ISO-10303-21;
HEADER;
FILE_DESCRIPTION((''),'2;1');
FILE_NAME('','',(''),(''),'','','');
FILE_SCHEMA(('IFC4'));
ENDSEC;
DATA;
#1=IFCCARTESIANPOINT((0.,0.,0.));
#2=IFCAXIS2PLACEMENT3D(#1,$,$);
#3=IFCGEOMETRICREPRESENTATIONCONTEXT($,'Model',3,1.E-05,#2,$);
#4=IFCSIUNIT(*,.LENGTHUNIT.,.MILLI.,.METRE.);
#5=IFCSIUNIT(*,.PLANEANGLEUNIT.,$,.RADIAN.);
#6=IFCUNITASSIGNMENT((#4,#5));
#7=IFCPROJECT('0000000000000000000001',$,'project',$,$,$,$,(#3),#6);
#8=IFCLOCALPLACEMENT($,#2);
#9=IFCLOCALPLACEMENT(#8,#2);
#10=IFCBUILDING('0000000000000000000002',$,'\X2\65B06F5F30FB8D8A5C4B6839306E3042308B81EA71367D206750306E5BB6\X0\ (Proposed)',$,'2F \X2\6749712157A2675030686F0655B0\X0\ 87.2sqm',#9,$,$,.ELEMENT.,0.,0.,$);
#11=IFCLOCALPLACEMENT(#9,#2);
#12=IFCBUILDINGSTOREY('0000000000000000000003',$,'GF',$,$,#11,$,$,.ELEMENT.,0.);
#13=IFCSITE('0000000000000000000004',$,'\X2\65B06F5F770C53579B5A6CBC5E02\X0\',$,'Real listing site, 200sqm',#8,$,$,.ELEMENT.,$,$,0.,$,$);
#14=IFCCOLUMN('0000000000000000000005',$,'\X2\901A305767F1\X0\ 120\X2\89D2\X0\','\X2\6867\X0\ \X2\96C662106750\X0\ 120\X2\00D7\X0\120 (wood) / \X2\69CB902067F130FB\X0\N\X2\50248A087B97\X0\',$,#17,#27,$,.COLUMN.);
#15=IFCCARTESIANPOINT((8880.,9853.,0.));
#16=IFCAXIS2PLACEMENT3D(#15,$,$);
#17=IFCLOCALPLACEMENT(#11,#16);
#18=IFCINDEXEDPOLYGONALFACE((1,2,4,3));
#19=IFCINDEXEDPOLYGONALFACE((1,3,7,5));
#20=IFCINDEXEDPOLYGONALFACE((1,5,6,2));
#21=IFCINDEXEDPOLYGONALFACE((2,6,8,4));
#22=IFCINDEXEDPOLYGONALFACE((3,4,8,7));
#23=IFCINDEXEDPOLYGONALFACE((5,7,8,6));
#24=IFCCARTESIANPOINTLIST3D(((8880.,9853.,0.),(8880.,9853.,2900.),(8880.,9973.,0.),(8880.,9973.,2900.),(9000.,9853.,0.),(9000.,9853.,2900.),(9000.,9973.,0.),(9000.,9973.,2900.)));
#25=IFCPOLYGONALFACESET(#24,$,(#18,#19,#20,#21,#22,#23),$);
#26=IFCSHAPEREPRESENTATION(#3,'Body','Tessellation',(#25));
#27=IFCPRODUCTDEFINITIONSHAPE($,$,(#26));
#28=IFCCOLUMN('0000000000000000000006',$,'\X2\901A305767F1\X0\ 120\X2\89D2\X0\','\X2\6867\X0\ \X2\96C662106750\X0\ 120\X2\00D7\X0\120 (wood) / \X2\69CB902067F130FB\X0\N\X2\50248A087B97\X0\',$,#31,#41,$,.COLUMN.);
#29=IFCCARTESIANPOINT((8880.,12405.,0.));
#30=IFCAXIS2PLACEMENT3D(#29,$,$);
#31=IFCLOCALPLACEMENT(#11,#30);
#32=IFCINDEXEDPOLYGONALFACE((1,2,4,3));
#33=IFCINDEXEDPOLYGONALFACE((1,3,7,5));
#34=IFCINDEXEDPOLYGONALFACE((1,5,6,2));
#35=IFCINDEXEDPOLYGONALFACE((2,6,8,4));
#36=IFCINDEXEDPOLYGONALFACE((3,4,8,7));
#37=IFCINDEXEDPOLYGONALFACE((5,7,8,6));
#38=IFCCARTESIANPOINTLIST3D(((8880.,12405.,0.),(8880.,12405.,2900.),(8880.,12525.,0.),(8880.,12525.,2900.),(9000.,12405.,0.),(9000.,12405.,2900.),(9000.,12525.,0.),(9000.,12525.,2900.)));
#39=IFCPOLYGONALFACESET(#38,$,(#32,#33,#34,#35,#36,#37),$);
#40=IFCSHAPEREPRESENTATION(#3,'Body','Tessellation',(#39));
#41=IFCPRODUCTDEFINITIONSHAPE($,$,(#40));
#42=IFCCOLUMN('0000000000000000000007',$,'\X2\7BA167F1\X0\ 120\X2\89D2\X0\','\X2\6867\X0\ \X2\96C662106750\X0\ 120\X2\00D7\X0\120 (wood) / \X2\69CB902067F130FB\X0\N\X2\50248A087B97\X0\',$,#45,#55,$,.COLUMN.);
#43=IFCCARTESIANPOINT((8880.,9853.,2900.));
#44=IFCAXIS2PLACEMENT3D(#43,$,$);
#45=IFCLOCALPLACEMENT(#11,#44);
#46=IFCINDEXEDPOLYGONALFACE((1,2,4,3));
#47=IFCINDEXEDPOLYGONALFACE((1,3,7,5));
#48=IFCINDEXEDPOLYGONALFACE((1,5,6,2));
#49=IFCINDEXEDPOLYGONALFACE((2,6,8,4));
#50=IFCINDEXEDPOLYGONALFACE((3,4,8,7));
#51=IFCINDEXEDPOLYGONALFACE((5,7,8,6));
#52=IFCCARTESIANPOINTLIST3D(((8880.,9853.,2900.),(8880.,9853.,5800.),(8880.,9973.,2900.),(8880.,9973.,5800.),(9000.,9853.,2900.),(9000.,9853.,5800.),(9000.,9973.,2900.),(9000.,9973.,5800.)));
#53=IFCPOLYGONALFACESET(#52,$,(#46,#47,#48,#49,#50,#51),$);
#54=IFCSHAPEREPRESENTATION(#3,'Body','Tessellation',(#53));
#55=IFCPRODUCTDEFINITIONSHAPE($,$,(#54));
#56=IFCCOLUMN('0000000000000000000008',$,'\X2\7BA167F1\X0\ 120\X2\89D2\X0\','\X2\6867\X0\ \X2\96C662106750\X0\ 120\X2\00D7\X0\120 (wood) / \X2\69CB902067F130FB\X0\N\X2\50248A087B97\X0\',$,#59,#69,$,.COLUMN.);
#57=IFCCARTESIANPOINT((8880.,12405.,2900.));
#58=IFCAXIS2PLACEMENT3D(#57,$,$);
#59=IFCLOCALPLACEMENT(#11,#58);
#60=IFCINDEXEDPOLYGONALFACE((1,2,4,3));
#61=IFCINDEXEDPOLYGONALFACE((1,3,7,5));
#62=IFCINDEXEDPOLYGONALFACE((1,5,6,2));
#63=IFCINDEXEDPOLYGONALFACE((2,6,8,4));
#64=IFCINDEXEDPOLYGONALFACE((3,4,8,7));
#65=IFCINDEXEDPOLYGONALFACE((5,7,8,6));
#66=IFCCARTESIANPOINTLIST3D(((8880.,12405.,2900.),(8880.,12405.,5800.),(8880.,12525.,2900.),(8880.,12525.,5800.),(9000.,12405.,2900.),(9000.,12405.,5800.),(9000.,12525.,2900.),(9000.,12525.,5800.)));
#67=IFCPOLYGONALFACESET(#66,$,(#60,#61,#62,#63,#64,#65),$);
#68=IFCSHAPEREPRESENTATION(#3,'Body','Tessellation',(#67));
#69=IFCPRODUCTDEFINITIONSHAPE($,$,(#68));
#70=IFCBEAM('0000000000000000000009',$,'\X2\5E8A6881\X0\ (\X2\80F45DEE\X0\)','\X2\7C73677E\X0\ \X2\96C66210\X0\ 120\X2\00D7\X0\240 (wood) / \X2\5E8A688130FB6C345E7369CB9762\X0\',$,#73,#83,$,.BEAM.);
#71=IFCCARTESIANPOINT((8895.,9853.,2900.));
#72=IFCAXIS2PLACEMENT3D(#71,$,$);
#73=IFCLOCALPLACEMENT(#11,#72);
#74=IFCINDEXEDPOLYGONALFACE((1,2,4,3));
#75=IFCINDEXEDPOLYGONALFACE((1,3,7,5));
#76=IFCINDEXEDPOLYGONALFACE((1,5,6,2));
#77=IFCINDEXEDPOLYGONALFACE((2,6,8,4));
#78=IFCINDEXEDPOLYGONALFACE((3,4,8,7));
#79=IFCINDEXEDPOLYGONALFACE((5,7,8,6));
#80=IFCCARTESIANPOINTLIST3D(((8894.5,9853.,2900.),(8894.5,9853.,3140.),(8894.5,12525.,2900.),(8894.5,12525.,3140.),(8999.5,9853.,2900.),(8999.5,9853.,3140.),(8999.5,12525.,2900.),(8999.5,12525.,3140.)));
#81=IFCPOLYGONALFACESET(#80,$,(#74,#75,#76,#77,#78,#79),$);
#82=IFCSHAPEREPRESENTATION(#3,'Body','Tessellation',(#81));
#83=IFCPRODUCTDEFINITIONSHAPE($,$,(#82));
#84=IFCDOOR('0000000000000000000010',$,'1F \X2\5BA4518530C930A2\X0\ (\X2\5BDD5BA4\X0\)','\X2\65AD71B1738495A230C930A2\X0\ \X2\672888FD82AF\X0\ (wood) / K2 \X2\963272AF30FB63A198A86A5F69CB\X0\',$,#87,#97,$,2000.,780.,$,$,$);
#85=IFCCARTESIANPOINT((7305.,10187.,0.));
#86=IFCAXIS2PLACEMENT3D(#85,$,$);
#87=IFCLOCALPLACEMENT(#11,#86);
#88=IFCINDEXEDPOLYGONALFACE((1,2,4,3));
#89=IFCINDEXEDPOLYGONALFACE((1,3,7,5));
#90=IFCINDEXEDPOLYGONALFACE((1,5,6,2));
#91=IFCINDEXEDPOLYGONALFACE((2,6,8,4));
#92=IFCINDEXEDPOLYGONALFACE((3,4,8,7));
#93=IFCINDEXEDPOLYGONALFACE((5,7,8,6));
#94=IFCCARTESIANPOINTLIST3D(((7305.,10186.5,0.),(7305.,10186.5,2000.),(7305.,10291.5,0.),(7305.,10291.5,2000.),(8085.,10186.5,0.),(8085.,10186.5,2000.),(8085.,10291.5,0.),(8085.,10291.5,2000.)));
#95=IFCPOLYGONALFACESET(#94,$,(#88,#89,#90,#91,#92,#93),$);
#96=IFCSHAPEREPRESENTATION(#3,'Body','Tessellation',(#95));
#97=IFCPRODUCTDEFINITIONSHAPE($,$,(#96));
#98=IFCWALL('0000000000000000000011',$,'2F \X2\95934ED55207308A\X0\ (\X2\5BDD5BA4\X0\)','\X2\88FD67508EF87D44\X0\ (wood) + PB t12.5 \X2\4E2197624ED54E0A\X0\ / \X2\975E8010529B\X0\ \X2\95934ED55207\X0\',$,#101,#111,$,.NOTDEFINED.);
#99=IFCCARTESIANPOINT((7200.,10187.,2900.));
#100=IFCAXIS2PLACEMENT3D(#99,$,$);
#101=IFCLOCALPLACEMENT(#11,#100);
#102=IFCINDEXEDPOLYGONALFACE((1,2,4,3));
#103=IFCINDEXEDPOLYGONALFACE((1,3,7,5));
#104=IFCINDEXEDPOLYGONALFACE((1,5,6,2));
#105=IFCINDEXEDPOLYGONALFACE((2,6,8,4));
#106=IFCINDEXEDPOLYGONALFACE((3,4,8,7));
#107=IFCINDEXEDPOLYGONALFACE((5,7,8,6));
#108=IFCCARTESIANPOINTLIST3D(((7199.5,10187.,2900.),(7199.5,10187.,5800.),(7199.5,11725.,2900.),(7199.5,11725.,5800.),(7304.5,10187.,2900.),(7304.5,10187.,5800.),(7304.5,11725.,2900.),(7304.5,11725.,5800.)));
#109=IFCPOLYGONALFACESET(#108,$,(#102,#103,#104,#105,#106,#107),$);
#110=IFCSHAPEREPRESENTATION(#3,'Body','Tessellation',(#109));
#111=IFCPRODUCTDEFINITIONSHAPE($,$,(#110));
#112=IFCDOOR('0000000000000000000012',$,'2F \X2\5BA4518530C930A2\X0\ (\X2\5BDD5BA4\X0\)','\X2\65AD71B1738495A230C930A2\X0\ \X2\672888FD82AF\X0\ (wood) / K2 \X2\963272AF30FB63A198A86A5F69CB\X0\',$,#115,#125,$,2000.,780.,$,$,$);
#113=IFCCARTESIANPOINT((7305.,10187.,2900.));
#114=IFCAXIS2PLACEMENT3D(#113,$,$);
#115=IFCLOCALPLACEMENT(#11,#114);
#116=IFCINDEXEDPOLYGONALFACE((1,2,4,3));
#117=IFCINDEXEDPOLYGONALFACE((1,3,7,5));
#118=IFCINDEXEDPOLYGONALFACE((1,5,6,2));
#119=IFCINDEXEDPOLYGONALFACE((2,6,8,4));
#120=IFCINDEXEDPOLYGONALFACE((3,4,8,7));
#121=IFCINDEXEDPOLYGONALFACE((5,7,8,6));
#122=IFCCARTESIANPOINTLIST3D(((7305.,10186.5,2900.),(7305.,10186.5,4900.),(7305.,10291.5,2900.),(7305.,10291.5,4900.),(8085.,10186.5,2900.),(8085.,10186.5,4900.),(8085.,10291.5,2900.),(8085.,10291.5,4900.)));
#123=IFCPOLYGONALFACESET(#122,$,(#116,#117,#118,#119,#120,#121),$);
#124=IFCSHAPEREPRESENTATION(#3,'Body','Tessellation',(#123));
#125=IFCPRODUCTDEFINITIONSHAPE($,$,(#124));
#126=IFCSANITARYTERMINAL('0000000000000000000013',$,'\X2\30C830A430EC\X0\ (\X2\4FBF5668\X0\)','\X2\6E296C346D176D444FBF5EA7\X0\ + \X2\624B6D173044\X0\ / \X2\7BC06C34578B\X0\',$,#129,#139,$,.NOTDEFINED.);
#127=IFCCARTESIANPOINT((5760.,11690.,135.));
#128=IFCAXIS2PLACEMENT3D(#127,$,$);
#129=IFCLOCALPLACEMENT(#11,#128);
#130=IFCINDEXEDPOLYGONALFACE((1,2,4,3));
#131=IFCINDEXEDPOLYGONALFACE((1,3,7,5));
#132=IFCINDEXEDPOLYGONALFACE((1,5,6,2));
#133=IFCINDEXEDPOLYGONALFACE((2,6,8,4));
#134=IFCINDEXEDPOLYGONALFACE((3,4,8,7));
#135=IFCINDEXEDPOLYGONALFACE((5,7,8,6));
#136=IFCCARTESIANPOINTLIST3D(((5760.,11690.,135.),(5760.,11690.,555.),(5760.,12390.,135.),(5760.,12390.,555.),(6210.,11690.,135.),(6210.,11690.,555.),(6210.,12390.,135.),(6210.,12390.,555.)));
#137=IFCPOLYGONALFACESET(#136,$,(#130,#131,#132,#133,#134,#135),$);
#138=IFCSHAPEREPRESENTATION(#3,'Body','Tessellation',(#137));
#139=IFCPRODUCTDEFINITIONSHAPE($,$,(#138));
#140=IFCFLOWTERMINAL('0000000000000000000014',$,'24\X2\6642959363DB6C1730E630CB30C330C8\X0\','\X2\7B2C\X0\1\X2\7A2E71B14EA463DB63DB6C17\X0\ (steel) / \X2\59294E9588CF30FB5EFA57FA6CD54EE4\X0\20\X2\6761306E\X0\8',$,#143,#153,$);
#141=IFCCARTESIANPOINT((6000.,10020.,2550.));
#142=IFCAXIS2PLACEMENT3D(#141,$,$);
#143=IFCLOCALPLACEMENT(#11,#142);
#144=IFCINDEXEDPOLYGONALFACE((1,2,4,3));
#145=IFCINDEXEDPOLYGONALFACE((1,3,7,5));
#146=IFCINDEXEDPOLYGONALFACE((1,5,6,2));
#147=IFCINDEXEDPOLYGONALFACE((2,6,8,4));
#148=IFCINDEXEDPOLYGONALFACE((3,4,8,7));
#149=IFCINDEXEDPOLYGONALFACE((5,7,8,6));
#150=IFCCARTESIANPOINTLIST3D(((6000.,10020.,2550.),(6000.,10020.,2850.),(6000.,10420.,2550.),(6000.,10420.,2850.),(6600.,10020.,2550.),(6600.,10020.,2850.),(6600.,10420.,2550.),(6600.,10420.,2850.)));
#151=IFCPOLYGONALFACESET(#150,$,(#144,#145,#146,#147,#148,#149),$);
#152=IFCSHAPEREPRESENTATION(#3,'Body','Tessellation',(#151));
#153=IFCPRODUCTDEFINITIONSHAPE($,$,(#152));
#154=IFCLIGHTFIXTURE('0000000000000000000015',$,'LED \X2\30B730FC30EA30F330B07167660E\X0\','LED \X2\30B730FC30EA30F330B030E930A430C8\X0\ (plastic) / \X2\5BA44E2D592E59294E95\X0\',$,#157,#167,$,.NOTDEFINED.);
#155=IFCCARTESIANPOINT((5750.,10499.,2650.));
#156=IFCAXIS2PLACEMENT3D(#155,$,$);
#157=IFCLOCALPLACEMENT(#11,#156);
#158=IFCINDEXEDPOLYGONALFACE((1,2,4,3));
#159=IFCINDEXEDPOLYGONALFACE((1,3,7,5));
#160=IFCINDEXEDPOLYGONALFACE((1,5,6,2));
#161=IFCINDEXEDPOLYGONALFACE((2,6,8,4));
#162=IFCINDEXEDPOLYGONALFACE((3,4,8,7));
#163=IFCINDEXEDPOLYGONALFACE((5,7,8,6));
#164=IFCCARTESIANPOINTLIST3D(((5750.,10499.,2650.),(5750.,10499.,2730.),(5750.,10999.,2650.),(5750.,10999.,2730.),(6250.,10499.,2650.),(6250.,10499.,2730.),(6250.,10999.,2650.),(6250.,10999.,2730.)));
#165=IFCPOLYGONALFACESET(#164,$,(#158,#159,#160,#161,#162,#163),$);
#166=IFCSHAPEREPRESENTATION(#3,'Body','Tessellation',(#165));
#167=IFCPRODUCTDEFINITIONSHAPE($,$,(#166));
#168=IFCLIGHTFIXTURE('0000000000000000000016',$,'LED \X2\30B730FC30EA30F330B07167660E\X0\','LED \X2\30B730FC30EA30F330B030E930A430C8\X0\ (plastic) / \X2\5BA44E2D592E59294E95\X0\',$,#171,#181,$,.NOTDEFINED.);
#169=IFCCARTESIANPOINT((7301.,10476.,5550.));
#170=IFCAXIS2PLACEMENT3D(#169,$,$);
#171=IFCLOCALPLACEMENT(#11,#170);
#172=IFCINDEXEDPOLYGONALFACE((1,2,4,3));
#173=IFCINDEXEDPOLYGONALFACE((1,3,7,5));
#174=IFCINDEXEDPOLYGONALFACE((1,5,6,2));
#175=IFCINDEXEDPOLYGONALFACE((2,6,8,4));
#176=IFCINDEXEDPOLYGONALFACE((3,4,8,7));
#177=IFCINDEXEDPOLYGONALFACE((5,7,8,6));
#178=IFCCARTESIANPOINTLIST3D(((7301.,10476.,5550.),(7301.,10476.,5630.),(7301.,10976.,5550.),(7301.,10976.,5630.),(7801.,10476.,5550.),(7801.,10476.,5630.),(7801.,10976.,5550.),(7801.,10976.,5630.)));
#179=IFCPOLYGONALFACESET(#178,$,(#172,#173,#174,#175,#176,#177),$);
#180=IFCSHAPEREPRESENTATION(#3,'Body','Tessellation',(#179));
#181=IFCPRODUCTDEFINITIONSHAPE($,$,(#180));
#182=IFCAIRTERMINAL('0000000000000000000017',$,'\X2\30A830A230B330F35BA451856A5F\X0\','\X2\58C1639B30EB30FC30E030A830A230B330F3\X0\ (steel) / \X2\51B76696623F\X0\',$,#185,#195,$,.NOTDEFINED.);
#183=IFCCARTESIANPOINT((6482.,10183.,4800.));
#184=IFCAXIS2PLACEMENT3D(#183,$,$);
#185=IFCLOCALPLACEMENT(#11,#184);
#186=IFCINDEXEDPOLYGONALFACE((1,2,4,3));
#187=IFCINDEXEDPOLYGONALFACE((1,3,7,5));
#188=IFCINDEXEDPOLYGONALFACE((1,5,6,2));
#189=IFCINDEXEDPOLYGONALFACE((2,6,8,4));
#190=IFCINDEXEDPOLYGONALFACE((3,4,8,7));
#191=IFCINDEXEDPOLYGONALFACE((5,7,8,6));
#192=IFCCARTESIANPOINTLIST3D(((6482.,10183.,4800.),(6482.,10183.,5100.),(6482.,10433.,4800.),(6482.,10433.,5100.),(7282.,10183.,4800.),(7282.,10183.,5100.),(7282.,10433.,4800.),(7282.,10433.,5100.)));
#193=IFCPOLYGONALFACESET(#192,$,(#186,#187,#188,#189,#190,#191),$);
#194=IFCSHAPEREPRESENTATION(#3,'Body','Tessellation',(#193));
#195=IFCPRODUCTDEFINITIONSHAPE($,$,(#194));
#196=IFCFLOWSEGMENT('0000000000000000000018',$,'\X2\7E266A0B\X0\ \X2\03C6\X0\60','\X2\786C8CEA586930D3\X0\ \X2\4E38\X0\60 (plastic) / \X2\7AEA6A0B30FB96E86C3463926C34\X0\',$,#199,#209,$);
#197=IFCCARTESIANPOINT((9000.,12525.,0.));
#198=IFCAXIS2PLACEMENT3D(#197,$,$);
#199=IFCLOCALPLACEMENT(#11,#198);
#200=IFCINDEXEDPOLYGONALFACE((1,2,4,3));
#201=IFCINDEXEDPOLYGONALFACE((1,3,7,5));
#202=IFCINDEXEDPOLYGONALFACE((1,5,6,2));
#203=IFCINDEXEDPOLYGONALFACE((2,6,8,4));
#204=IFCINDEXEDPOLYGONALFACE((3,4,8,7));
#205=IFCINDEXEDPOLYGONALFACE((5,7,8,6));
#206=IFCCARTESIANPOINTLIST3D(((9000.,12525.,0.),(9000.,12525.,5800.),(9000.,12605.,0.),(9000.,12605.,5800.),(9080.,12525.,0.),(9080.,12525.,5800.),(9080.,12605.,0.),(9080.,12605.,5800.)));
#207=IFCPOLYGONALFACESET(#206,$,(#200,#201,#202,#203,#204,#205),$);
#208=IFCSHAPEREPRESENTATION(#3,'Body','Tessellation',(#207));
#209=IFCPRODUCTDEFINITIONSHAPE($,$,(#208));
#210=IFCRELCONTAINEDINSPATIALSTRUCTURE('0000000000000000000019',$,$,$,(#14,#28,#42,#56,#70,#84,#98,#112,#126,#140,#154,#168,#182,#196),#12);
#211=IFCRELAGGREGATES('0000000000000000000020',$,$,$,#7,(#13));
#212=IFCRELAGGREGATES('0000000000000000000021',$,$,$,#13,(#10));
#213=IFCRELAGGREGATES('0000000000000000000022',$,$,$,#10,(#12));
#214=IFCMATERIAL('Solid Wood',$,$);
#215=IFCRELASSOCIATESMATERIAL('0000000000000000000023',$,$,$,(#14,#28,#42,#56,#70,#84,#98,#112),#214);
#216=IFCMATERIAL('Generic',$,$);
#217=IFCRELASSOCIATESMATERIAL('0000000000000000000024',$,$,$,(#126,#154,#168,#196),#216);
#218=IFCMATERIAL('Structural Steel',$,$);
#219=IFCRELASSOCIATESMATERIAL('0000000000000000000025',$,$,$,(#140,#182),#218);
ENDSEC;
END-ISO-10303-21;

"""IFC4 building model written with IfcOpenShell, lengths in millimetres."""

from ifc_helpers import new_model, si_unit, frame, frame_2d, origin, place, context, project, spatial, rectangle, extrude, material, element, save


model = new_model("IFC4")

# Units and contexts
model_context = context("Model", 3, precision=1e-05, world=origin())
ifc_project = project(units=[si_unit("LENGTHUNIT", "METRE", prefix="MILLI"), si_unit("PLANEANGLEUNIT", "RADIAN")], contexts=[model_context])

# Site, building, storey
site_placement = place(None, origin())
site = spatial("IfcSite", under=ifc_project, at=site_placement, Name="新潟県南魚沼市", ObjectType="Real listing site, 200sqm", CompositionType="ELEMENT", RefElevation=0.0)
building_placement = place(site_placement, origin())
building = spatial("IfcBuilding", under=site, at=building_placement, Name="新潟・越屋根のある自然素材の家 (Proposed)", ObjectType="2F 杉無垢材と漆喰 87.2sqm", CompositionType="ELEMENT", ElevationOfRefHeight=0.0, ElevationOfTerrain=0.0)
storey_placement = place(building_placement, origin())
storey = spatial("IfcBuildingStorey", under=building, at=storey_placement, Name="GF", CompositionType="ELEMENT", Elevation=0.0)

# Columns
ifc_material_1 = material(Name="Solid Wood")
column_1_placement = place(storey_placement, frame((8880.0, 9853.0, 0.0)))
element("IfcColumn", 1, at=column_1_placement, inside=storey, material=ifc_material_1, Name="通し柱 120角", Description="桧 集成材 120×120 (wood) / 構造柱・N値計算", PredefinedType="COLUMN", context=model_context, shape_type="SweptSolid", body=[
    extrude(rectangle(XDim=120.0, YDim=120.0, at=frame_2d((60.0, 60.0))), frame((8880.0, 9853.0, 0.0)), (0.0, 0.0, 1.0), 2900.0),
])
column_2_placement = place(storey_placement, frame((8880.0, 12405.0, 0.0)))
element("IfcColumn", 2, at=column_2_placement, inside=storey, material=ifc_material_1, Name="通し柱 120角", Description="桧 集成材 120×120 (wood) / 構造柱・N値計算", PredefinedType="COLUMN", context=model_context, shape_type="SweptSolid", body=[
    extrude(rectangle(XDim=120.0, YDim=120.0, at=frame_2d((60.0, 60.0))), frame((8880.0, 12405.0, 0.0)), (0.0, 0.0, 1.0), 2900.0),
])
column_3_placement = place(storey_placement, frame((8880.0, 9853.0, 2900.0)))
element("IfcColumn", 3, at=column_3_placement, inside=storey, material=ifc_material_1, Name="管柱 120角", Description="桧 集成材 120×120 (wood) / 構造柱・N値計算", PredefinedType="COLUMN", context=model_context, shape_type="SweptSolid", body=[
    extrude(rectangle(XDim=120.0, YDim=120.0, at=frame_2d((60.0, 60.0))), frame((8880.0, 9853.0, 2900.0)), (0.0, 0.0, 1.0), 2900.0),
])
column_4_placement = place(storey_placement, frame((8880.0, 12405.0, 2900.0)))
element("IfcColumn", 4, at=column_4_placement, inside=storey, material=ifc_material_1, Name="管柱 120角", Description="桧 集成材 120×120 (wood) / 構造柱・N値計算", PredefinedType="COLUMN", context=model_context, shape_type="SweptSolid", body=[
    extrude(rectangle(XDim=120.0, YDim=120.0, at=frame_2d((60.0, 60.0))), frame((8880.0, 12405.0, 2900.0)), (0.0, 0.0, 1.0), 2900.0),
])

# Beam
beam_1_placement = place(storey_placement, frame((8895.0, 9853.0, 2900.0)))
element("IfcBeam", 5, at=beam_1_placement, inside=storey, material=ifc_material_1, Name="床梁 (胴差)", Description="米松 集成 120×240 (wood) / 床梁・水平構面", PredefinedType="BEAM", context=model_context, shape_type="SweptSolid", body=[
    extrude(rectangle(XDim=105.0, YDim=2672.0, at=frame_2d((52.0, 1336.0))), frame((8895.0, 9853.0, 2900.0)), (0.0, 0.0, 1.0), 240.0),
])

# Door
door_1_placement = place(storey_placement, frame((7305.0, 10187.0, 0.0)))
element("IfcDoor", 6, at=door_1_placement, inside=storey, material=ifc_material_1, Name="1F 室内ドア (寝室)", Description="断熱玄関ドア 木製芯 (wood) / K2 防犯・採風機構", OverallHeight=2000.0, OverallWidth=780.0, context=model_context, shape_type="SweptSolid", body=[
    extrude(rectangle(XDim=780.0, YDim=105.0, at=frame_2d((390.0, 52.0))), frame((7305.0, 10187.0, 0.0)), (0.0, 0.0, 1.0), 2000.0),
])

# Wall
wall_1_placement = place(storey_placement, frame((7200.0, 10187.0, 2900.0)))
element("IfcWall", 7, at=wall_1_placement, inside=storey, material=ifc_material_1, Name="2F 間仕切り (寝室)", Description="製材軸組 (wood) + PB t12.5 両面仕上 / 非耐力 間仕切", PredefinedType="NOTDEFINED", context=model_context, shape_type="SweptSolid", body=[
    extrude(rectangle(XDim=105.0, YDim=1538.0, at=frame_2d((52.0, 769.0))), frame((7200.0, 10187.0, 2900.0)), (0.0, 0.0, 1.0), 2900.0),
])

# Door
door_2_placement = place(storey_placement, frame((7305.0, 10187.0, 2900.0)))
element("IfcDoor", 8, at=door_2_placement, inside=storey, material=ifc_material_1, Name="2F 室内ドア (寝室)", Description="断熱玄関ドア 木製芯 (wood) / K2 防犯・採風機構", OverallHeight=2000.0, OverallWidth=780.0, context=model_context, shape_type="SweptSolid", body=[
    extrude(rectangle(XDim=780.0, YDim=105.0, at=frame_2d((390.0, 52.0))), frame((7305.0, 10187.0, 2900.0)), (0.0, 0.0, 1.0), 2000.0),
])

# Sanitary terminal
ifc_material_2 = material(Name="Generic")
sanitary_terminal_placement = place(storey_placement, frame((5760.0, 11690.0, 135.0)))
element("IfcSanitaryTerminal", 9, at=sanitary_terminal_placement, inside=storey, material=ifc_material_2, Name="トイレ (便器)", Description="温水洗浄便座 + 手洗い / 節水型", PredefinedType="NOTDEFINED", context=model_context, shape_type="SweptSolid", body=[
    extrude(rectangle(XDim=450.0, YDim=700.0, at=frame_2d((225.0, 350.0))), frame((5760.0, 11690.0, 135.0)), (0.0, 0.0, 1.0), 420.0),
])

# Flow terminal
ifc_material_3 = material(Name="Structural Steel")
flow_terminal_placement = place(storey_placement, frame((6000.0, 10020.0, 2550.0)))
element("IfcFlowTerminal", 10, at=flow_terminal_placement, inside=storey, material=ifc_material_3, Name="24時間換気ユニット", Description="第1種熱交換換気 (steel) / 天井裏・建基法令20条の8", context=model_context, shape_type="SweptSolid", body=[
    extrude(rectangle(XDim=600.0, YDim=400.0, at=frame_2d((300.0, 200.0))), frame((6000.0, 10020.0, 2550.0)), (0.0, 0.0, 1.0), 300.0),
])

# Light fixtures
light_fixture_1_placement = place(storey_placement, frame((5750.0, 10499.0, 2650.0)))
element("IfcLightFixture", 11, at=light_fixture_1_placement, inside=storey, material=ifc_material_2, Name="LED シーリング照明", Description="LED シーリングライト (plastic) / 室中央天井", PredefinedType="NOTDEFINED", context=model_context, shape_type="SweptSolid", body=[
    extrude(rectangle(XDim=500.0, YDim=500.0, at=frame_2d((250.0, 250.0))), frame((5750.0, 10499.0, 2650.0)), (0.0, 0.0, 1.0), 80.0),
])
light_fixture_2_placement = place(storey_placement, frame((7301.0, 10476.0, 5550.0)))
element("IfcLightFixture", 12, at=light_fixture_2_placement, inside=storey, material=ifc_material_2, Name="LED シーリング照明", Description="LED シーリングライト (plastic) / 室中央天井", PredefinedType="NOTDEFINED", context=model_context, shape_type="SweptSolid", body=[
    extrude(rectangle(XDim=500.0, YDim=500.0, at=frame_2d((250.0, 250.0))), frame((7301.0, 10476.0, 5550.0)), (0.0, 0.0, 1.0), 80.0),
])

# Air terminal
air_terminal_placement = place(storey_placement, frame((6482.0, 10183.0, 4800.0)))
element("IfcAirTerminal", 13, at=air_terminal_placement, inside=storey, material=ifc_material_3, Name="エアコン室内機", Description="壁掛ルームエアコン (steel) / 冷暖房", PredefinedType="NOTDEFINED", context=model_context, shape_type="SweptSolid", body=[
    extrude(rectangle(XDim=800.0, YDim=250.0, at=frame_2d((400.0, 125.0))), frame((6482.0, 10183.0, 4800.0)), (0.0, 0.0, 1.0), 300.0),
])

# Flow segment
flow_segment_placement = place(storey_placement, frame((9000.0, 12525.0, 0.0)))
element("IfcFlowSegment", 14, at=flow_segment_placement, inside=storey, material=ifc_material_2, Name="縦樋 φ60", Description="硬質塩ビ 丸60 (plastic) / 竪樋・雨水排水", context=model_context, shape_type="SweptSolid", body=[
    extrude(rectangle(XDim=80.0, YDim=80.0, at=frame_2d((40.0, 40.0))), frame((9000.0, 12525.0, 0.0)), (0.0, 0.0, 1.0), 5800.0),
])

save(model, "model.ifc")
